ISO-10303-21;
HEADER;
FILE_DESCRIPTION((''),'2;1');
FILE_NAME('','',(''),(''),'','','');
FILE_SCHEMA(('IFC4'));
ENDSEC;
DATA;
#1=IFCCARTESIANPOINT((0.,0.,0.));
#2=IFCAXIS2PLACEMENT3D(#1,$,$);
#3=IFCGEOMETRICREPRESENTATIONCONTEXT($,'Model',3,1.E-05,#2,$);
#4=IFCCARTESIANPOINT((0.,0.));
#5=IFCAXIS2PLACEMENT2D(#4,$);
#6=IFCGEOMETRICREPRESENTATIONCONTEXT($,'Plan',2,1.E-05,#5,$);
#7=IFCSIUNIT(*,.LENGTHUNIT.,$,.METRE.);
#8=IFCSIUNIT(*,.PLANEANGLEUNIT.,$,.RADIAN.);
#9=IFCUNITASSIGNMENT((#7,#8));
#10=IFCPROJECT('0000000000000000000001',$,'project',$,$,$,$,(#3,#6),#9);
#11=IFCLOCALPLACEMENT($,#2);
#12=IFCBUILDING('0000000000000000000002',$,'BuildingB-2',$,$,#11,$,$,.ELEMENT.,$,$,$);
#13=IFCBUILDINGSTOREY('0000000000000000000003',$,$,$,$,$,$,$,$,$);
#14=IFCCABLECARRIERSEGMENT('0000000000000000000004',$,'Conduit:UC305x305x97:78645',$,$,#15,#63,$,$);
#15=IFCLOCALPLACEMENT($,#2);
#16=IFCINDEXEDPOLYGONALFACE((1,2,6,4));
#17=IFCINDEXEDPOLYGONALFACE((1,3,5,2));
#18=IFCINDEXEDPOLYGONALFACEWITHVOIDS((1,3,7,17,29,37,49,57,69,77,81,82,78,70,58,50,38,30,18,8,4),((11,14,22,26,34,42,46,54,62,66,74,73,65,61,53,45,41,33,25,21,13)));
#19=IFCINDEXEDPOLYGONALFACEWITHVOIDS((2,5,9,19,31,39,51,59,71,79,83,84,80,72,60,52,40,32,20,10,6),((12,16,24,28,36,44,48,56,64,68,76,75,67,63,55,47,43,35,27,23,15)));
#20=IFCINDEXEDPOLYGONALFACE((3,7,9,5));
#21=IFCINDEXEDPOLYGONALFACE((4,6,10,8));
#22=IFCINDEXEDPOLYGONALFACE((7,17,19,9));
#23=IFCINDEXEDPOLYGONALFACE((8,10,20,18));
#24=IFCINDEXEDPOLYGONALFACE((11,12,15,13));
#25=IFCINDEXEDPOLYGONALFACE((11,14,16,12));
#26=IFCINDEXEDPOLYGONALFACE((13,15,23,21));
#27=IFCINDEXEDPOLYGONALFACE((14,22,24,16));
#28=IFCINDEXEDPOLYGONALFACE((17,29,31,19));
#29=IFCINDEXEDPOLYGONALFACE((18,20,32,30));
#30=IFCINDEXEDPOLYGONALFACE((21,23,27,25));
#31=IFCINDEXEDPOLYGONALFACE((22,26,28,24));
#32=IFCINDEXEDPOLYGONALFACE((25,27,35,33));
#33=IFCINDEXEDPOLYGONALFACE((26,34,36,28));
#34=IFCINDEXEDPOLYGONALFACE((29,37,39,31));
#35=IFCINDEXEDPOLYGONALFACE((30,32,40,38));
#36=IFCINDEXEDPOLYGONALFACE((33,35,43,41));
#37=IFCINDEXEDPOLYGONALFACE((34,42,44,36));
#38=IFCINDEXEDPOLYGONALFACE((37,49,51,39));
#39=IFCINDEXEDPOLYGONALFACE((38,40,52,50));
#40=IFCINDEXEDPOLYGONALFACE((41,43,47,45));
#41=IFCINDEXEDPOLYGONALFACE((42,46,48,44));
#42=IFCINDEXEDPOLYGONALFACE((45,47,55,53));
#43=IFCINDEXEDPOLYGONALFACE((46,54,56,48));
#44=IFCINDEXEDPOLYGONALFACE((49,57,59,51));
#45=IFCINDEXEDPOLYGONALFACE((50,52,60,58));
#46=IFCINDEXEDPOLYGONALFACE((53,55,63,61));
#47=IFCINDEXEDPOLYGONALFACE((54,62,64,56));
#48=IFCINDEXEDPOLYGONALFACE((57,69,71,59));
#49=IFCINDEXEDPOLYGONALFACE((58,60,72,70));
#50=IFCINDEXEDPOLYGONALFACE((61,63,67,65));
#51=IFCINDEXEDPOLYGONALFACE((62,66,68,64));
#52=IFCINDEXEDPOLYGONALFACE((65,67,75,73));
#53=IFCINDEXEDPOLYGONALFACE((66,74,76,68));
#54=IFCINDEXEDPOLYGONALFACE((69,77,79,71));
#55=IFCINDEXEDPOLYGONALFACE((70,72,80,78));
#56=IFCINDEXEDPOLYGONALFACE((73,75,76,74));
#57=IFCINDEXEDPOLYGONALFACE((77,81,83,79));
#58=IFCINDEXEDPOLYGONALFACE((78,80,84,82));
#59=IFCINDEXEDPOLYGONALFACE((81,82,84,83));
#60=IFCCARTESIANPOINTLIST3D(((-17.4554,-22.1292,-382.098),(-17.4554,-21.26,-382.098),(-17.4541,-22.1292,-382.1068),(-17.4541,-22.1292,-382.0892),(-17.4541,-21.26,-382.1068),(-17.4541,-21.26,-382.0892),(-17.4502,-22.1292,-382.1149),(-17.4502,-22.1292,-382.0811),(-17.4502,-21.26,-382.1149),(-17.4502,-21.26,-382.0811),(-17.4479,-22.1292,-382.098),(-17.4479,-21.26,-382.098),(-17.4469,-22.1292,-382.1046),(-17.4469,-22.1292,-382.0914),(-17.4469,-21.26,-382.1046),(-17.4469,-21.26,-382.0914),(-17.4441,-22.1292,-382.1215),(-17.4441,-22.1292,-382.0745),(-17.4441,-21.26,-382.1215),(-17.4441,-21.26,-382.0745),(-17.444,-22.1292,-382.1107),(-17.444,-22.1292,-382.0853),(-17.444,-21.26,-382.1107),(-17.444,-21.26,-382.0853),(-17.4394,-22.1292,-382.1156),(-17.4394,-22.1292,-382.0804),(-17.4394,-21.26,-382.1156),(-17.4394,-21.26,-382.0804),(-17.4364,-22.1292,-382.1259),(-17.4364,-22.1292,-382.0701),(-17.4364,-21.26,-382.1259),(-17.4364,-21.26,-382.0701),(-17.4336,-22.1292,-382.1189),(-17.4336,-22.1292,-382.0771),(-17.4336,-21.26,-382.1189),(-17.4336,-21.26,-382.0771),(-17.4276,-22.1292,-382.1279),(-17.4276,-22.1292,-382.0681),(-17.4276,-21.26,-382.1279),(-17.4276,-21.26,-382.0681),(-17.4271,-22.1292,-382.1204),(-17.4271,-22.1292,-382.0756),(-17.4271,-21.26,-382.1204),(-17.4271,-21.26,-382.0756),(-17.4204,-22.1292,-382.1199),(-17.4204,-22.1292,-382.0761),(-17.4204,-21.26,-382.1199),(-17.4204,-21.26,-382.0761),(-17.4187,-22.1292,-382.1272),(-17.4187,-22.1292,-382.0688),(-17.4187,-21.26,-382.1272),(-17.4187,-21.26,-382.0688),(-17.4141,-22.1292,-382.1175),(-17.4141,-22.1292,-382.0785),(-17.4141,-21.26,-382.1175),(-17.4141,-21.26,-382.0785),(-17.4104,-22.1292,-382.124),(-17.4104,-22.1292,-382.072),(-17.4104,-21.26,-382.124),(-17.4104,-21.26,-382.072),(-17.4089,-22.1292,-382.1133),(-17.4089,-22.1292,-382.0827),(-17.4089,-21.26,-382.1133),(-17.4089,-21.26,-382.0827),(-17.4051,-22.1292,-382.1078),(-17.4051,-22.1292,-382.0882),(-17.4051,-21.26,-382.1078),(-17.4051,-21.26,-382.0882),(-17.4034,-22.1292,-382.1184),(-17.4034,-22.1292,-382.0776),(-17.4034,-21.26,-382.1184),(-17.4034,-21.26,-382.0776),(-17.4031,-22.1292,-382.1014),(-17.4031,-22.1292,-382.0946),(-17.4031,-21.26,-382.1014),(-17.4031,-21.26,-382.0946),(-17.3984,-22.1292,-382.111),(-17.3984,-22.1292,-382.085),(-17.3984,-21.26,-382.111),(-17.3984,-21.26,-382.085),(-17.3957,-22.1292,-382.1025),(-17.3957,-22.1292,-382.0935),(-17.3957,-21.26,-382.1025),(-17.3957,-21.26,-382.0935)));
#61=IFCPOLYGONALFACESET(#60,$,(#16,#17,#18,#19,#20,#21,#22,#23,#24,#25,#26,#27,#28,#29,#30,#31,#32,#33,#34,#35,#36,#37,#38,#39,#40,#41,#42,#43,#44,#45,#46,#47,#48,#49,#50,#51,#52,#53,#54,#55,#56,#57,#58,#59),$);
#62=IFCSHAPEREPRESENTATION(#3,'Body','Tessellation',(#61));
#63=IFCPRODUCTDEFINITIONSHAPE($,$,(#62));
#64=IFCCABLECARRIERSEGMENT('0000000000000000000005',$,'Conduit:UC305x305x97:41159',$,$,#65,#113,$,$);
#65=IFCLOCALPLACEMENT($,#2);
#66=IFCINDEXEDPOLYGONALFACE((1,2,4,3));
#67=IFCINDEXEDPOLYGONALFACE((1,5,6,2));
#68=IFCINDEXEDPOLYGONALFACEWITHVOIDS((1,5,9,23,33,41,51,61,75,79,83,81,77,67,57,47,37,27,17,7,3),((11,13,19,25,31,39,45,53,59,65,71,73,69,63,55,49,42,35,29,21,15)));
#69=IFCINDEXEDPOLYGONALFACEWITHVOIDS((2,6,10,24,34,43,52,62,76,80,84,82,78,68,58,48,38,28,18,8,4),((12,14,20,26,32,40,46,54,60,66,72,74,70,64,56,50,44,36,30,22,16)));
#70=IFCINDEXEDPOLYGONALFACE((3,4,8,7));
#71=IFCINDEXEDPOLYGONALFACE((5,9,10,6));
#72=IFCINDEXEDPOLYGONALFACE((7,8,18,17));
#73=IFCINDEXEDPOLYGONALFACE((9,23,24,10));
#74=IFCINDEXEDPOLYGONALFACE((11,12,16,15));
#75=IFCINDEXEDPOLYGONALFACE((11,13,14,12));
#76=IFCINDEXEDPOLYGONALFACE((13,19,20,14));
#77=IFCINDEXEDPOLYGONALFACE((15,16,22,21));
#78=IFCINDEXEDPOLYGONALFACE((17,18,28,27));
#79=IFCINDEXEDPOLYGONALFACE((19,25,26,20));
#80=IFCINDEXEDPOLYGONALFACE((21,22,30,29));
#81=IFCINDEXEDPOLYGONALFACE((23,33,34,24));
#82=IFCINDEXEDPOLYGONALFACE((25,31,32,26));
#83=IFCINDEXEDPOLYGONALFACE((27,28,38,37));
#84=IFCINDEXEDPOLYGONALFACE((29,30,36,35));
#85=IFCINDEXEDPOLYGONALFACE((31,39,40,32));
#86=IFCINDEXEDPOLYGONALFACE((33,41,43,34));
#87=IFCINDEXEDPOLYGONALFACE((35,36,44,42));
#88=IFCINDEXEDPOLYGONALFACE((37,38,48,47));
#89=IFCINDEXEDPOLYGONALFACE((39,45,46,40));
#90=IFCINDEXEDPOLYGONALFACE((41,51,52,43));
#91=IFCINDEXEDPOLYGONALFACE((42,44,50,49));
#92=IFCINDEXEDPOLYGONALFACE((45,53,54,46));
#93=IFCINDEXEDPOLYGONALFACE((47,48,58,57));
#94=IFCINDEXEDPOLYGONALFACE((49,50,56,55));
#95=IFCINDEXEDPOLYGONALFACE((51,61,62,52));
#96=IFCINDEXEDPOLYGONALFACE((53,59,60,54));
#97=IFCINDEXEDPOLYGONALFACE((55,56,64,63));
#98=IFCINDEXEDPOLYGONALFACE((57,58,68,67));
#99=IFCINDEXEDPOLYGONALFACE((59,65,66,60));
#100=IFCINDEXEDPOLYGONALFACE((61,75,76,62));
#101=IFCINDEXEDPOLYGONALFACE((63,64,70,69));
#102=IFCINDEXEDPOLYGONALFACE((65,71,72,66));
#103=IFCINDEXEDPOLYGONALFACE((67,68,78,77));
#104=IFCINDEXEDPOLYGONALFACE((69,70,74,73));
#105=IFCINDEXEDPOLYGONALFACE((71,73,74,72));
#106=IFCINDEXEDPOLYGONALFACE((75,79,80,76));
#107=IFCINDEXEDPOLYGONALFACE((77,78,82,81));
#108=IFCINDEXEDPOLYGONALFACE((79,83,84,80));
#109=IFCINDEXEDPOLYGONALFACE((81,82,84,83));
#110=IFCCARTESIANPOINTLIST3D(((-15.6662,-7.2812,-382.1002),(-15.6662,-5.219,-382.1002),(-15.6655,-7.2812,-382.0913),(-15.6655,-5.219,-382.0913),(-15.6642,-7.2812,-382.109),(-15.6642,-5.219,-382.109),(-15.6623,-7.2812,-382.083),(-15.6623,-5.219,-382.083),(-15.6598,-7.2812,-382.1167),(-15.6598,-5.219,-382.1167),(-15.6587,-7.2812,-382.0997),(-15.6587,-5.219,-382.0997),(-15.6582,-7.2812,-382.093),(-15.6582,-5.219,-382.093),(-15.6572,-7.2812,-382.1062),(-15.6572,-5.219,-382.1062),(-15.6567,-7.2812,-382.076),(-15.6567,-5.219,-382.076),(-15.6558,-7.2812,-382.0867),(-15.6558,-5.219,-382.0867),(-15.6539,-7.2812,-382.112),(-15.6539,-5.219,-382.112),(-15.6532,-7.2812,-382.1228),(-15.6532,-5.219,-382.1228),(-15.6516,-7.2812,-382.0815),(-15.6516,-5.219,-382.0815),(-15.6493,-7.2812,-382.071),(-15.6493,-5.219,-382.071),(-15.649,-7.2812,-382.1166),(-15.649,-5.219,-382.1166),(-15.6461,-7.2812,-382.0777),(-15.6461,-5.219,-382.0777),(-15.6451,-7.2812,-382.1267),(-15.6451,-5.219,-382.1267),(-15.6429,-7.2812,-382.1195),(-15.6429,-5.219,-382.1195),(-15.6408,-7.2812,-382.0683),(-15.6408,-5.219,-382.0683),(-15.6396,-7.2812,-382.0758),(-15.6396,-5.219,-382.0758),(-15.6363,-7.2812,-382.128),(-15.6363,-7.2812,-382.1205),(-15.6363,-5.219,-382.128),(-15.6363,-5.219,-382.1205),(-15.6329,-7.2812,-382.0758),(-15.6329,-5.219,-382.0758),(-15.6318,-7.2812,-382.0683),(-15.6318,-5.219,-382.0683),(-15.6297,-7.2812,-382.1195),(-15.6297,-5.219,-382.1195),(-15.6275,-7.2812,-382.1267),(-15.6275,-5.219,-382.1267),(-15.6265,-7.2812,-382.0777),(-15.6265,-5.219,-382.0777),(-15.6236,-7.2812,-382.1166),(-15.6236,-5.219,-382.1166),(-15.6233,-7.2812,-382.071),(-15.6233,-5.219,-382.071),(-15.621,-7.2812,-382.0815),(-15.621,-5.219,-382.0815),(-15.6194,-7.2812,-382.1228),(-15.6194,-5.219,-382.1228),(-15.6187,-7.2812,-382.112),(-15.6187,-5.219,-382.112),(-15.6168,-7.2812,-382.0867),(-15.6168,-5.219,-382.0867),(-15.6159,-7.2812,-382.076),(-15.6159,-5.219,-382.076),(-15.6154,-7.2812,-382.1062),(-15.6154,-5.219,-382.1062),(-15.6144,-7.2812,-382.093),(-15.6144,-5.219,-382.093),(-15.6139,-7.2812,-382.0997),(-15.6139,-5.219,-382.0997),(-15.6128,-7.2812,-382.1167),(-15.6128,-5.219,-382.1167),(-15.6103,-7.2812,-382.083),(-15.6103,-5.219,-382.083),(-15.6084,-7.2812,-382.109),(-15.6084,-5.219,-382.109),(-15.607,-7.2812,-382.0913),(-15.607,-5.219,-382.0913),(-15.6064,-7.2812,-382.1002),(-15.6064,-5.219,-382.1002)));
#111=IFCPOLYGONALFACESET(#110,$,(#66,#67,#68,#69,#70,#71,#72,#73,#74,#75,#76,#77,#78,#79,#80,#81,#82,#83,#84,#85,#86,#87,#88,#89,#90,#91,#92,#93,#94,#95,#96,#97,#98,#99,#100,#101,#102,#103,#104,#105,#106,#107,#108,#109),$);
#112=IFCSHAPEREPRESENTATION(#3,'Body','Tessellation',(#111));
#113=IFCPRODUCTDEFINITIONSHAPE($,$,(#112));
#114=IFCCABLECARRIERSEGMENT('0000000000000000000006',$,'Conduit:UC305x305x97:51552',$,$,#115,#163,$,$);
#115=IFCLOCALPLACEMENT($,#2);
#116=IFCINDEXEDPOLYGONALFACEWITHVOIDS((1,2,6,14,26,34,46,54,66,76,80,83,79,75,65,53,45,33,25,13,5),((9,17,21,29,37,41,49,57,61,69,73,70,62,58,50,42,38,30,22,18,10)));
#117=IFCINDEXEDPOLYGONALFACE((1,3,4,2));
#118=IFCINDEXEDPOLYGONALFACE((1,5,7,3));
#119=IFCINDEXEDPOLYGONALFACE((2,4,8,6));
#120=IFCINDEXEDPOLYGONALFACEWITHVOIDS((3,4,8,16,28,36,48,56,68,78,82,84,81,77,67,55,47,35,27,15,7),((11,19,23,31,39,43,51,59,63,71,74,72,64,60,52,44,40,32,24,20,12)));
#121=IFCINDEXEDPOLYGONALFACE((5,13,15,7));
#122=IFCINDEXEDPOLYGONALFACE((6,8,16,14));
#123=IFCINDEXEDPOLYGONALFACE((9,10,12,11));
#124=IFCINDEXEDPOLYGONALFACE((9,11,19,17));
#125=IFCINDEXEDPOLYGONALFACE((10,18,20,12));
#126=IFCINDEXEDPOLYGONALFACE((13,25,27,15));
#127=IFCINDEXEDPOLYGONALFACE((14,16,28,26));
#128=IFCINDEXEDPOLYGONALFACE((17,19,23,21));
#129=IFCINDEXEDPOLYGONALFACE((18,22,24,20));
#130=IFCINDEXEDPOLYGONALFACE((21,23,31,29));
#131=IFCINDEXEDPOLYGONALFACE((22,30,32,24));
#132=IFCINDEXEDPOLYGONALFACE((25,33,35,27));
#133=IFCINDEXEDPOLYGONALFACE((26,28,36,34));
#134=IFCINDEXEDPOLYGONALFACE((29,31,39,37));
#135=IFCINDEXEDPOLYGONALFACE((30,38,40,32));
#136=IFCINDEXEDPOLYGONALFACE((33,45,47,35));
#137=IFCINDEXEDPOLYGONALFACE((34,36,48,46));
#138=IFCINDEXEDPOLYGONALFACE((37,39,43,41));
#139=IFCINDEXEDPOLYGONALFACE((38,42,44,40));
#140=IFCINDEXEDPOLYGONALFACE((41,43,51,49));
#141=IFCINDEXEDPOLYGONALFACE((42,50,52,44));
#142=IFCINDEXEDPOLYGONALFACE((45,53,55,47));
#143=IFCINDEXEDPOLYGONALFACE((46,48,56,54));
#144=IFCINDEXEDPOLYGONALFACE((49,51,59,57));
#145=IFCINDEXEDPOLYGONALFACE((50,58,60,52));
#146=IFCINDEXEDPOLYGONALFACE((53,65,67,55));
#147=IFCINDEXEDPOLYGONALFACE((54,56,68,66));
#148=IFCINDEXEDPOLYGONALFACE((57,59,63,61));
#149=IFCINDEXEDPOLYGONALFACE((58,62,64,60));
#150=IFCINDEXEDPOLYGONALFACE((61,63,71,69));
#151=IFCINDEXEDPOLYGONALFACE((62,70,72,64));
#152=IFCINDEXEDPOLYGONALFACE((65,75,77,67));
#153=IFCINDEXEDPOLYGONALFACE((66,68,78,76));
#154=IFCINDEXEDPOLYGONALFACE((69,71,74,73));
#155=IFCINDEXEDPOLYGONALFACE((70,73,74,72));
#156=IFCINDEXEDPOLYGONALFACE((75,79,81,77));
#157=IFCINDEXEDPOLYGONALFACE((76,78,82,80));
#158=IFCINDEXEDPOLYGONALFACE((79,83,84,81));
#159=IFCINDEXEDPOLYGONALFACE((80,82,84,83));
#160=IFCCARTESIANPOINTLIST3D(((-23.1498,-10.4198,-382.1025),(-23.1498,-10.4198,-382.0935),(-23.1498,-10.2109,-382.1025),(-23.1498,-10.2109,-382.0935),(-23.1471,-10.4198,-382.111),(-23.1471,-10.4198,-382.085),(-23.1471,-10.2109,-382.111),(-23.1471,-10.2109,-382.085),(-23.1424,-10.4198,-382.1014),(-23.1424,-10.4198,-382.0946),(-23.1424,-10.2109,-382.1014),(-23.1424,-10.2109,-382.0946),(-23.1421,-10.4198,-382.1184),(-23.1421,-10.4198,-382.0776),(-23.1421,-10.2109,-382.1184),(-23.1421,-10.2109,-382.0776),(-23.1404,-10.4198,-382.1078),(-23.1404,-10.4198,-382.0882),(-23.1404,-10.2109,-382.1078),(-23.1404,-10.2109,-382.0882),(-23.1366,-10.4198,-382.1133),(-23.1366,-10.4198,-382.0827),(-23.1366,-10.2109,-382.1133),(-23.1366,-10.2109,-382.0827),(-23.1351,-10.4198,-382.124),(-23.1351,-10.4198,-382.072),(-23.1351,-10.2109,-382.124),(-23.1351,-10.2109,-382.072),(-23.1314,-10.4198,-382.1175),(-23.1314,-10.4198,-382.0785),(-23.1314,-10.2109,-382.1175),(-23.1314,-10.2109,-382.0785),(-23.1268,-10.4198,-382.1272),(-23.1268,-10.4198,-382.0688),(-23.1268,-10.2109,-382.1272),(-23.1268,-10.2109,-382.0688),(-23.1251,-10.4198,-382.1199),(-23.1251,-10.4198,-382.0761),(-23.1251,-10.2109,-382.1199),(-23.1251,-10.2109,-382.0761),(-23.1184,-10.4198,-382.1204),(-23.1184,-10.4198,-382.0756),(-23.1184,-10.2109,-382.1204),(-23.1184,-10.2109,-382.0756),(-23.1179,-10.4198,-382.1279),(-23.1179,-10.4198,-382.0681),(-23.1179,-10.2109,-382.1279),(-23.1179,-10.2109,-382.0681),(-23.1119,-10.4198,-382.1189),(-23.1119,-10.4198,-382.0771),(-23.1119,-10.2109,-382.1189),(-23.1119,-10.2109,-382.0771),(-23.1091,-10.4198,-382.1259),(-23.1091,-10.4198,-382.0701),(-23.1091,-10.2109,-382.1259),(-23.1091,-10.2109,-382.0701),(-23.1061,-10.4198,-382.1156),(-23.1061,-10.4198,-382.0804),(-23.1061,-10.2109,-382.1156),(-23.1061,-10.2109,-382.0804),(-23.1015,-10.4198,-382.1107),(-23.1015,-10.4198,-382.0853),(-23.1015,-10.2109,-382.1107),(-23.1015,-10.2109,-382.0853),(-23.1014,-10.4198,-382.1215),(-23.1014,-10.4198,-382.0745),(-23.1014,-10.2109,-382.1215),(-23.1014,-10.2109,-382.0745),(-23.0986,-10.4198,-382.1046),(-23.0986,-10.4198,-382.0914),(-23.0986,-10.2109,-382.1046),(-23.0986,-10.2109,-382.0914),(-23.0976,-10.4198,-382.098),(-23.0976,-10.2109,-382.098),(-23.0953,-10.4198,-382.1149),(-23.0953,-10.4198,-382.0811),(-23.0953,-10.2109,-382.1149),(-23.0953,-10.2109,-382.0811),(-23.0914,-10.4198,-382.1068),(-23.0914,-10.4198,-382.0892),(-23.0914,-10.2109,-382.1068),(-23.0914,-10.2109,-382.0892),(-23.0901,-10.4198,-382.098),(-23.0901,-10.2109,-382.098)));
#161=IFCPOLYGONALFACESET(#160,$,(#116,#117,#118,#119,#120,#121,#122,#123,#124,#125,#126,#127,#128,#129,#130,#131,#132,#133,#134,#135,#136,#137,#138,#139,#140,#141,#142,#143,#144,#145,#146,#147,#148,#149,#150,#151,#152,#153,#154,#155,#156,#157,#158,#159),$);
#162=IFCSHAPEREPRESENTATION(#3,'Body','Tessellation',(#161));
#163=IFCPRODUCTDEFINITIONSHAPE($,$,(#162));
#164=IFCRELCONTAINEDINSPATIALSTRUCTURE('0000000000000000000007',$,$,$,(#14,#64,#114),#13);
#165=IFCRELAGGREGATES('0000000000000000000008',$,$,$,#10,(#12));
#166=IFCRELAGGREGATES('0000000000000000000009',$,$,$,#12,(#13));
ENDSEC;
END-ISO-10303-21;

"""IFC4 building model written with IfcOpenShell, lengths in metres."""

from ifc_helpers import new_model, entity, si_unit, origin, origin_2d, place, context, project, spatial, element, save


model = new_model("IFC4")

# Units and contexts
model_context = context("Model", 3, precision=1e-05, world=origin())
plan_context = context("Plan", 2, precision=1e-05, world=origin_2d())
ifc_project = project(units=[si_unit("LENGTHUNIT", "METRE"), si_unit("PLANEANGLEUNIT", "RADIAN")], contexts=[model_context, plan_context])

# Building, storey
building_placement = place(None, origin())
building = spatial("IfcBuilding", under=ifc_project, at=building_placement, Name="BuildingB-2", CompositionType="ELEMENT")
storey = spatial("IfcBuildingStorey", under=building)

# Cable carrier segments
element("IfcCableCarrierSegment", 1, inside=storey, Name="Conduit:UC305x305x97:78645", context=model_context, shape_type="AdvancedSweptSolid", body=[
    entity("IfcSweptDiskSolid", entity("IfcCompositeCurve", [entity("IfcCompositeCurveSegment", "CONTINUOUS", False, entity("IfcPolyline", [entity("IfcCartesianPoint", [17.4254, 22.1292, 382.098]), entity("IfcCartesianPoint", [17.4254, 21.26, 382.098])]))], False), 0.03, 0.0225),
])
element("IfcCableCarrierSegment", 2, inside=storey, Name="Conduit:UC305x305x97:41159", context=model_context, shape_type="AdvancedSweptSolid", body=[
    entity("IfcSweptDiskSolid", entity("IfcCompositeCurve", [entity("IfcCompositeCurveSegment", "CONTINUOUS", False, entity("IfcPolyline", [entity("IfcCartesianPoint", [15.6363, 7.2812, 382.098]), entity("IfcCartesianPoint", [15.6363, 5.219, 382.098])]))], False), 0.03, 0.0225),
])
element("IfcCableCarrierSegment", 3, inside=storey, Name="Conduit:UC305x305x97:51552", context=model_context, shape_type="AdvancedSweptSolid", body=[
    entity("IfcSweptDiskSolid", entity("IfcCompositeCurve", [entity("IfcCompositeCurveSegment", "CONTINUOUS", False, entity("IfcPolyline", [entity("IfcCartesianPoint", [23.1201, 10.2109, 382.098]), entity("IfcCartesianPoint", [23.1201, 10.4198, 382.098])]))], False), 0.03, 0.0225),
])

save(model, "model.ifc")
